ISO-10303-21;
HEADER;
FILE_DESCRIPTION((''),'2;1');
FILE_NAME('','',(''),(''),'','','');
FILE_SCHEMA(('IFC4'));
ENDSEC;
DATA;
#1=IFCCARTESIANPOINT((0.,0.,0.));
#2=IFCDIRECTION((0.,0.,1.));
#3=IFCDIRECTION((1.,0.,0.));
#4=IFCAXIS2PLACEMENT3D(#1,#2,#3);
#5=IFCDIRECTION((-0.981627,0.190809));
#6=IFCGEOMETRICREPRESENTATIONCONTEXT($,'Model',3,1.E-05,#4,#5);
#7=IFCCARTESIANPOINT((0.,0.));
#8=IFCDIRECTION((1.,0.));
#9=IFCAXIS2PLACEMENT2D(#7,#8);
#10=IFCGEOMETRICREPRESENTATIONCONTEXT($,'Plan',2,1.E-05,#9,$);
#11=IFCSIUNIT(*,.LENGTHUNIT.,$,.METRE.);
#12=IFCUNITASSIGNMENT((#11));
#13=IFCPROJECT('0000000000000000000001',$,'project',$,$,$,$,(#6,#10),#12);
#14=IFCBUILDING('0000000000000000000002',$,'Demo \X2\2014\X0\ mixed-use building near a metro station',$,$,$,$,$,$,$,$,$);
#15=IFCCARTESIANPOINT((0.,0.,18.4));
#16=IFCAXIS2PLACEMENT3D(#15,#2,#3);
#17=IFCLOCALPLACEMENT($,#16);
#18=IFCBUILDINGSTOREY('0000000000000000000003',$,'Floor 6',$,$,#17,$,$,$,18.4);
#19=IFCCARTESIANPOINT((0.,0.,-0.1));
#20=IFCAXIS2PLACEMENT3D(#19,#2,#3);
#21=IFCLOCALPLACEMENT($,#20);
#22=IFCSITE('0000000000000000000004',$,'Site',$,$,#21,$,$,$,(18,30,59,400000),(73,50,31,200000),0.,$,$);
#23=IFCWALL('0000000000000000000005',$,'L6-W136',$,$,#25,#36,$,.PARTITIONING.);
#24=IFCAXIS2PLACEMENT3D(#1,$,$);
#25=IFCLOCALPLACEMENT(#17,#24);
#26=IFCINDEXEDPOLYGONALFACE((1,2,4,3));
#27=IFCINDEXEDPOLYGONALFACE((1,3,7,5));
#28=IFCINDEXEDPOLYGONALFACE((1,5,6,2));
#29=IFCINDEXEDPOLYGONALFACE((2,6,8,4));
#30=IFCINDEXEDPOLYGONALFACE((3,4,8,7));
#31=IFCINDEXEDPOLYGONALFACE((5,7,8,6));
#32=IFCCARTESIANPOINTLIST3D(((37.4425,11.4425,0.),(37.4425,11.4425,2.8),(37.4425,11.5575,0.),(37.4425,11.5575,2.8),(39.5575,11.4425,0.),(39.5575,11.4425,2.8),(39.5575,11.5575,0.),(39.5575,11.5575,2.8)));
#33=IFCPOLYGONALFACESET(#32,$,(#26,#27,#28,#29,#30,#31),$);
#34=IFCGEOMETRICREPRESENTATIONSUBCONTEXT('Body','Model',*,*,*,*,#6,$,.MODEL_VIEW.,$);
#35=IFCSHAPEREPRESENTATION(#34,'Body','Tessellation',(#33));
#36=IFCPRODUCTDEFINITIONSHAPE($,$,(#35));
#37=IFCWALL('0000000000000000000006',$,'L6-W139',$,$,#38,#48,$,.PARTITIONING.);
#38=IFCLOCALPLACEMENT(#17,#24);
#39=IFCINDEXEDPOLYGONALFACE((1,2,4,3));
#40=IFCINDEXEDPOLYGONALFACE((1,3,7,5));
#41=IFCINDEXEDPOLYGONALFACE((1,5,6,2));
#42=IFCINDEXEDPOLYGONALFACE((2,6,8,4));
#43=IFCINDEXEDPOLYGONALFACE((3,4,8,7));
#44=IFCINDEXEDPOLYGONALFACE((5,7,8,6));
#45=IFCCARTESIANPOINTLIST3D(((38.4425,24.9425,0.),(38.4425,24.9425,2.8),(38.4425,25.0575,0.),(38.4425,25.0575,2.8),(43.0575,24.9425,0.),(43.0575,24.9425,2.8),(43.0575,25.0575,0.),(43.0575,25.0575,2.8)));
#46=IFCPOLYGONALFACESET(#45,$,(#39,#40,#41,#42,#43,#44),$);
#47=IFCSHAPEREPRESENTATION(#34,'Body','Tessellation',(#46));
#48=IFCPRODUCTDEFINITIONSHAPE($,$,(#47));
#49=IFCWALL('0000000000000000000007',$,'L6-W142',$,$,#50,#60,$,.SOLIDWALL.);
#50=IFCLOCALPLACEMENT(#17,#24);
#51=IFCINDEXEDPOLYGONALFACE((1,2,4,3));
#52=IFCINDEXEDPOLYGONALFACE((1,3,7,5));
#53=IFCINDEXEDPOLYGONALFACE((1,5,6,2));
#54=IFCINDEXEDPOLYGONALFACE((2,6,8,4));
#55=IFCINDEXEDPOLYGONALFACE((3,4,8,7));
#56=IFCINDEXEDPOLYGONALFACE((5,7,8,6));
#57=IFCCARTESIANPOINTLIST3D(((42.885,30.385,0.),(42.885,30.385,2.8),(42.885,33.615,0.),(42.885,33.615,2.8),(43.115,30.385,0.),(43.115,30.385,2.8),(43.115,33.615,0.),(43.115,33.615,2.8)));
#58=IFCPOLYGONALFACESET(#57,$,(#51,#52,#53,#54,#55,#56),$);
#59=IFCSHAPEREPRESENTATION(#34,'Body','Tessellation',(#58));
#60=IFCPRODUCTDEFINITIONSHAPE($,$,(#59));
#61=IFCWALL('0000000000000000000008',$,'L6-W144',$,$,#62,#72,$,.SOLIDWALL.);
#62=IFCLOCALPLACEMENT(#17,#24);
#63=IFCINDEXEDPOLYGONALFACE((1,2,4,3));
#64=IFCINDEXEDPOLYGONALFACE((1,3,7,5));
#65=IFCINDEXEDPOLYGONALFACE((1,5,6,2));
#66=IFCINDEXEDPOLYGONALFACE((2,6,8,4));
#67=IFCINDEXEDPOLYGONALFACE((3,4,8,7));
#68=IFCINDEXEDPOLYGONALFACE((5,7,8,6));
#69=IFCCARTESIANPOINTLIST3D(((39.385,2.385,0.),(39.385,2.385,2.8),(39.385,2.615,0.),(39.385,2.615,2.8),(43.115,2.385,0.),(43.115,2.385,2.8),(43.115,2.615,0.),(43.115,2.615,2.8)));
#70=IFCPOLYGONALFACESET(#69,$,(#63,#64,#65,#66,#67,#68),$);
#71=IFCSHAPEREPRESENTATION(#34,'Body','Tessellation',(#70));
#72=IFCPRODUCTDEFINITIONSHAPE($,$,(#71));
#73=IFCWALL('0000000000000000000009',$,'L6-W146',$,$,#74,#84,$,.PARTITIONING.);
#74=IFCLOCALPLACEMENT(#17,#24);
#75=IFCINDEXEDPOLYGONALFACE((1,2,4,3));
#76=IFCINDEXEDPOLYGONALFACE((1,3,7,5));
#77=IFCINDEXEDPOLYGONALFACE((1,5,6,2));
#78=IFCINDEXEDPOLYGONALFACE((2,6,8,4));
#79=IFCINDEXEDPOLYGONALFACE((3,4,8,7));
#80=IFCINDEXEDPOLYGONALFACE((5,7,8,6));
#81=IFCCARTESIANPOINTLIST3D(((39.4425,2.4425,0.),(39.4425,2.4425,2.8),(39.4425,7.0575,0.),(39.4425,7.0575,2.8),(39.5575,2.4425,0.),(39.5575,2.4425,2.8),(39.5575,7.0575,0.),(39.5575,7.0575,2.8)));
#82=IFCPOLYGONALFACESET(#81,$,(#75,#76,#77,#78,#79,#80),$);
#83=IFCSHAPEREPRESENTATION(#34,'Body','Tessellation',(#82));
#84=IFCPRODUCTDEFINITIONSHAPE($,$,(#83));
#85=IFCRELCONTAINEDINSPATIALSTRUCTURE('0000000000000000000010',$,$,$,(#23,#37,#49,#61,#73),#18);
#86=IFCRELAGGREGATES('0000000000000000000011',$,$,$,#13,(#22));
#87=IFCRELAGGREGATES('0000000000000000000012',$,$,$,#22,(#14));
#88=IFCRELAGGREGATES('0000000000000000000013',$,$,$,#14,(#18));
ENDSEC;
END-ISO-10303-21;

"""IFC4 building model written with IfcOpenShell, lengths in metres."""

from ifc_helpers import new_model, si_unit, direction, frame, origin_with_axes, origin_2d_with_axis, place, context, subcontext, project, spatial, line, indexed_curve, outline, extrude, element, save


model = new_model("IFC4")

# Units and contexts
model_context = context("Model", 3, precision=1e-05, world=origin_with_axes(), true_north=direction((-0.981627, 0.190809)))
plan_context = context("Plan", 2, precision=1e-05, world=origin_2d_with_axis())
body_context = subcontext(model_context, "Body", "Model", "MODEL_VIEW")
ifc_project = project(units=[si_unit("LENGTHUNIT", "METRE")], contexts=[model_context, plan_context])

# Site, building, storey
site_placement = place(None, frame((0.0, 0.0, -0.1), z_axis=(0.0, 0.0, 1.0), x_axis=(1.0, 0.0, 0.0)))
site = spatial("IfcSite", under=ifc_project, at=site_placement, Name="Site", RefLatitude=(18, 30, 59, 400000), RefLongitude=(73, 50, 31, 200000), RefElevation=0.0)
building = spatial("IfcBuilding", under=site, Name="Demo — mixed-use building near a metro station")
storey_placement = place(None, frame((0.0, 0.0, 18.4), z_axis=(0.0, 0.0, 1.0), x_axis=(1.0, 0.0, 0.0)))
storey = spatial("IfcBuildingStorey", under=building, at=storey_placement, Name="Floor 6", Elevation=18.4)

# Wall
wall_1_placement = place(storey_placement, frame((0.0, 0.0, -18.4), z_axis=(0.0, 0.0, 1.0), x_axis=(1.0, 0.0, 0.0)))
element("IfcWall", 1, at=wall_1_placement, inside=storey, Name="L6-W136", PredefinedType="PARTITIONING", context=body_context, shape_type="SweptSolid", body=[
    extrude(outline(indexed_curve([(37.4425, 11.5575), (39.5575, 11.5575), (39.5575, 11.4425), (37.4425, 11.4425)], segments=[line(1, 2, 3, 4, 1)])), frame((0.0, 0.0, 18.4), z_axis=(0.0, 0.0, 1.0), x_axis=(1.0, 0.0, 0.0)), (0.0, 0.0, 1.0), 2.8),
])

# Wall
wall_2_placement = place(storey_placement, frame((0.0, 0.0, -18.4), z_axis=(0.0, 0.0, 1.0), x_axis=(1.0, 0.0, 0.0)))
element("IfcWall", 2, at=wall_2_placement, inside=storey, Name="L6-W139", PredefinedType="PARTITIONING", context=body_context, shape_type="SweptSolid", body=[
    extrude(outline(indexed_curve([(43.0575, 24.9425), (38.4425, 24.9425), (38.4425, 25.0575), (43.0575, 25.0575)], segments=[line(1, 2, 3, 4, 1)])), frame((0.0, 0.0, 18.4), z_axis=(0.0, 0.0, 1.0), x_axis=(1.0, 0.0, 0.0)), (0.0, 0.0, 1.0), 2.8),
])

# Wall
wall_3_placement = place(storey_placement, frame((0.0, 0.0, -18.4), z_axis=(0.0, 0.0, 1.0), x_axis=(1.0, 0.0, 0.0)))
element("IfcWall", 3, at=wall_3_placement, inside=storey, Name="L6-W142", PredefinedType="SOLIDWALL", context=body_context, shape_type="SweptSolid", body=[
    extrude(outline(indexed_curve([(42.885, 30.385), (42.885, 33.615), (43.115, 33.615), (43.115, 30.385)], segments=[line(1, 2, 3, 4, 1)])), frame((0.0, 0.0, 18.4), z_axis=(0.0, 0.0, 1.0), x_axis=(1.0, 0.0, 0.0)), (0.0, 0.0, 1.0), 2.8),
])

# Wall
wall_4_placement = place(storey_placement, frame((0.0, 0.0, -18.4), z_axis=(0.0, 0.0, 1.0), x_axis=(1.0, 0.0, 0.0)))
element("IfcWall", 4, at=wall_4_placement, inside=storey, Name="L6-W144", PredefinedType="SOLIDWALL", context=body_context, shape_type="SweptSolid", body=[
    extrude(outline(indexed_curve([(39.385, 2.615), (43.115, 2.615), (43.115, 2.385), (39.385, 2.385)], segments=[line(1, 2, 3, 4, 1)])), frame((0.0, 0.0, 18.4), z_axis=(0.0, 0.0, 1.0), x_axis=(1.0, 0.0, 0.0)), (0.0, 0.0, 1.0), 2.8),
])

# Wall
wall_5_placement = place(storey_placement, frame((0.0, 0.0, -18.4), z_axis=(0.0, 0.0, 1.0), x_axis=(1.0, 0.0, 0.0)))
element("IfcWall", 5, at=wall_5_placement, inside=storey, Name="L6-W146", PredefinedType="PARTITIONING", context=body_context, shape_type="SweptSolid", body=[
    extrude(outline(indexed_curve([(39.5575, 7.0575), (39.5575, 2.4425), (39.4425, 2.4425), (39.4425, 7.0575)], segments=[line(1, 2, 3, 4, 1)])), frame((0.0, 0.0, 18.4), z_axis=(0.0, 0.0, 1.0), x_axis=(1.0, 0.0, 0.0)), (0.0, 0.0, 1.0), 2.8),
])

save(model, "model.ifc")
